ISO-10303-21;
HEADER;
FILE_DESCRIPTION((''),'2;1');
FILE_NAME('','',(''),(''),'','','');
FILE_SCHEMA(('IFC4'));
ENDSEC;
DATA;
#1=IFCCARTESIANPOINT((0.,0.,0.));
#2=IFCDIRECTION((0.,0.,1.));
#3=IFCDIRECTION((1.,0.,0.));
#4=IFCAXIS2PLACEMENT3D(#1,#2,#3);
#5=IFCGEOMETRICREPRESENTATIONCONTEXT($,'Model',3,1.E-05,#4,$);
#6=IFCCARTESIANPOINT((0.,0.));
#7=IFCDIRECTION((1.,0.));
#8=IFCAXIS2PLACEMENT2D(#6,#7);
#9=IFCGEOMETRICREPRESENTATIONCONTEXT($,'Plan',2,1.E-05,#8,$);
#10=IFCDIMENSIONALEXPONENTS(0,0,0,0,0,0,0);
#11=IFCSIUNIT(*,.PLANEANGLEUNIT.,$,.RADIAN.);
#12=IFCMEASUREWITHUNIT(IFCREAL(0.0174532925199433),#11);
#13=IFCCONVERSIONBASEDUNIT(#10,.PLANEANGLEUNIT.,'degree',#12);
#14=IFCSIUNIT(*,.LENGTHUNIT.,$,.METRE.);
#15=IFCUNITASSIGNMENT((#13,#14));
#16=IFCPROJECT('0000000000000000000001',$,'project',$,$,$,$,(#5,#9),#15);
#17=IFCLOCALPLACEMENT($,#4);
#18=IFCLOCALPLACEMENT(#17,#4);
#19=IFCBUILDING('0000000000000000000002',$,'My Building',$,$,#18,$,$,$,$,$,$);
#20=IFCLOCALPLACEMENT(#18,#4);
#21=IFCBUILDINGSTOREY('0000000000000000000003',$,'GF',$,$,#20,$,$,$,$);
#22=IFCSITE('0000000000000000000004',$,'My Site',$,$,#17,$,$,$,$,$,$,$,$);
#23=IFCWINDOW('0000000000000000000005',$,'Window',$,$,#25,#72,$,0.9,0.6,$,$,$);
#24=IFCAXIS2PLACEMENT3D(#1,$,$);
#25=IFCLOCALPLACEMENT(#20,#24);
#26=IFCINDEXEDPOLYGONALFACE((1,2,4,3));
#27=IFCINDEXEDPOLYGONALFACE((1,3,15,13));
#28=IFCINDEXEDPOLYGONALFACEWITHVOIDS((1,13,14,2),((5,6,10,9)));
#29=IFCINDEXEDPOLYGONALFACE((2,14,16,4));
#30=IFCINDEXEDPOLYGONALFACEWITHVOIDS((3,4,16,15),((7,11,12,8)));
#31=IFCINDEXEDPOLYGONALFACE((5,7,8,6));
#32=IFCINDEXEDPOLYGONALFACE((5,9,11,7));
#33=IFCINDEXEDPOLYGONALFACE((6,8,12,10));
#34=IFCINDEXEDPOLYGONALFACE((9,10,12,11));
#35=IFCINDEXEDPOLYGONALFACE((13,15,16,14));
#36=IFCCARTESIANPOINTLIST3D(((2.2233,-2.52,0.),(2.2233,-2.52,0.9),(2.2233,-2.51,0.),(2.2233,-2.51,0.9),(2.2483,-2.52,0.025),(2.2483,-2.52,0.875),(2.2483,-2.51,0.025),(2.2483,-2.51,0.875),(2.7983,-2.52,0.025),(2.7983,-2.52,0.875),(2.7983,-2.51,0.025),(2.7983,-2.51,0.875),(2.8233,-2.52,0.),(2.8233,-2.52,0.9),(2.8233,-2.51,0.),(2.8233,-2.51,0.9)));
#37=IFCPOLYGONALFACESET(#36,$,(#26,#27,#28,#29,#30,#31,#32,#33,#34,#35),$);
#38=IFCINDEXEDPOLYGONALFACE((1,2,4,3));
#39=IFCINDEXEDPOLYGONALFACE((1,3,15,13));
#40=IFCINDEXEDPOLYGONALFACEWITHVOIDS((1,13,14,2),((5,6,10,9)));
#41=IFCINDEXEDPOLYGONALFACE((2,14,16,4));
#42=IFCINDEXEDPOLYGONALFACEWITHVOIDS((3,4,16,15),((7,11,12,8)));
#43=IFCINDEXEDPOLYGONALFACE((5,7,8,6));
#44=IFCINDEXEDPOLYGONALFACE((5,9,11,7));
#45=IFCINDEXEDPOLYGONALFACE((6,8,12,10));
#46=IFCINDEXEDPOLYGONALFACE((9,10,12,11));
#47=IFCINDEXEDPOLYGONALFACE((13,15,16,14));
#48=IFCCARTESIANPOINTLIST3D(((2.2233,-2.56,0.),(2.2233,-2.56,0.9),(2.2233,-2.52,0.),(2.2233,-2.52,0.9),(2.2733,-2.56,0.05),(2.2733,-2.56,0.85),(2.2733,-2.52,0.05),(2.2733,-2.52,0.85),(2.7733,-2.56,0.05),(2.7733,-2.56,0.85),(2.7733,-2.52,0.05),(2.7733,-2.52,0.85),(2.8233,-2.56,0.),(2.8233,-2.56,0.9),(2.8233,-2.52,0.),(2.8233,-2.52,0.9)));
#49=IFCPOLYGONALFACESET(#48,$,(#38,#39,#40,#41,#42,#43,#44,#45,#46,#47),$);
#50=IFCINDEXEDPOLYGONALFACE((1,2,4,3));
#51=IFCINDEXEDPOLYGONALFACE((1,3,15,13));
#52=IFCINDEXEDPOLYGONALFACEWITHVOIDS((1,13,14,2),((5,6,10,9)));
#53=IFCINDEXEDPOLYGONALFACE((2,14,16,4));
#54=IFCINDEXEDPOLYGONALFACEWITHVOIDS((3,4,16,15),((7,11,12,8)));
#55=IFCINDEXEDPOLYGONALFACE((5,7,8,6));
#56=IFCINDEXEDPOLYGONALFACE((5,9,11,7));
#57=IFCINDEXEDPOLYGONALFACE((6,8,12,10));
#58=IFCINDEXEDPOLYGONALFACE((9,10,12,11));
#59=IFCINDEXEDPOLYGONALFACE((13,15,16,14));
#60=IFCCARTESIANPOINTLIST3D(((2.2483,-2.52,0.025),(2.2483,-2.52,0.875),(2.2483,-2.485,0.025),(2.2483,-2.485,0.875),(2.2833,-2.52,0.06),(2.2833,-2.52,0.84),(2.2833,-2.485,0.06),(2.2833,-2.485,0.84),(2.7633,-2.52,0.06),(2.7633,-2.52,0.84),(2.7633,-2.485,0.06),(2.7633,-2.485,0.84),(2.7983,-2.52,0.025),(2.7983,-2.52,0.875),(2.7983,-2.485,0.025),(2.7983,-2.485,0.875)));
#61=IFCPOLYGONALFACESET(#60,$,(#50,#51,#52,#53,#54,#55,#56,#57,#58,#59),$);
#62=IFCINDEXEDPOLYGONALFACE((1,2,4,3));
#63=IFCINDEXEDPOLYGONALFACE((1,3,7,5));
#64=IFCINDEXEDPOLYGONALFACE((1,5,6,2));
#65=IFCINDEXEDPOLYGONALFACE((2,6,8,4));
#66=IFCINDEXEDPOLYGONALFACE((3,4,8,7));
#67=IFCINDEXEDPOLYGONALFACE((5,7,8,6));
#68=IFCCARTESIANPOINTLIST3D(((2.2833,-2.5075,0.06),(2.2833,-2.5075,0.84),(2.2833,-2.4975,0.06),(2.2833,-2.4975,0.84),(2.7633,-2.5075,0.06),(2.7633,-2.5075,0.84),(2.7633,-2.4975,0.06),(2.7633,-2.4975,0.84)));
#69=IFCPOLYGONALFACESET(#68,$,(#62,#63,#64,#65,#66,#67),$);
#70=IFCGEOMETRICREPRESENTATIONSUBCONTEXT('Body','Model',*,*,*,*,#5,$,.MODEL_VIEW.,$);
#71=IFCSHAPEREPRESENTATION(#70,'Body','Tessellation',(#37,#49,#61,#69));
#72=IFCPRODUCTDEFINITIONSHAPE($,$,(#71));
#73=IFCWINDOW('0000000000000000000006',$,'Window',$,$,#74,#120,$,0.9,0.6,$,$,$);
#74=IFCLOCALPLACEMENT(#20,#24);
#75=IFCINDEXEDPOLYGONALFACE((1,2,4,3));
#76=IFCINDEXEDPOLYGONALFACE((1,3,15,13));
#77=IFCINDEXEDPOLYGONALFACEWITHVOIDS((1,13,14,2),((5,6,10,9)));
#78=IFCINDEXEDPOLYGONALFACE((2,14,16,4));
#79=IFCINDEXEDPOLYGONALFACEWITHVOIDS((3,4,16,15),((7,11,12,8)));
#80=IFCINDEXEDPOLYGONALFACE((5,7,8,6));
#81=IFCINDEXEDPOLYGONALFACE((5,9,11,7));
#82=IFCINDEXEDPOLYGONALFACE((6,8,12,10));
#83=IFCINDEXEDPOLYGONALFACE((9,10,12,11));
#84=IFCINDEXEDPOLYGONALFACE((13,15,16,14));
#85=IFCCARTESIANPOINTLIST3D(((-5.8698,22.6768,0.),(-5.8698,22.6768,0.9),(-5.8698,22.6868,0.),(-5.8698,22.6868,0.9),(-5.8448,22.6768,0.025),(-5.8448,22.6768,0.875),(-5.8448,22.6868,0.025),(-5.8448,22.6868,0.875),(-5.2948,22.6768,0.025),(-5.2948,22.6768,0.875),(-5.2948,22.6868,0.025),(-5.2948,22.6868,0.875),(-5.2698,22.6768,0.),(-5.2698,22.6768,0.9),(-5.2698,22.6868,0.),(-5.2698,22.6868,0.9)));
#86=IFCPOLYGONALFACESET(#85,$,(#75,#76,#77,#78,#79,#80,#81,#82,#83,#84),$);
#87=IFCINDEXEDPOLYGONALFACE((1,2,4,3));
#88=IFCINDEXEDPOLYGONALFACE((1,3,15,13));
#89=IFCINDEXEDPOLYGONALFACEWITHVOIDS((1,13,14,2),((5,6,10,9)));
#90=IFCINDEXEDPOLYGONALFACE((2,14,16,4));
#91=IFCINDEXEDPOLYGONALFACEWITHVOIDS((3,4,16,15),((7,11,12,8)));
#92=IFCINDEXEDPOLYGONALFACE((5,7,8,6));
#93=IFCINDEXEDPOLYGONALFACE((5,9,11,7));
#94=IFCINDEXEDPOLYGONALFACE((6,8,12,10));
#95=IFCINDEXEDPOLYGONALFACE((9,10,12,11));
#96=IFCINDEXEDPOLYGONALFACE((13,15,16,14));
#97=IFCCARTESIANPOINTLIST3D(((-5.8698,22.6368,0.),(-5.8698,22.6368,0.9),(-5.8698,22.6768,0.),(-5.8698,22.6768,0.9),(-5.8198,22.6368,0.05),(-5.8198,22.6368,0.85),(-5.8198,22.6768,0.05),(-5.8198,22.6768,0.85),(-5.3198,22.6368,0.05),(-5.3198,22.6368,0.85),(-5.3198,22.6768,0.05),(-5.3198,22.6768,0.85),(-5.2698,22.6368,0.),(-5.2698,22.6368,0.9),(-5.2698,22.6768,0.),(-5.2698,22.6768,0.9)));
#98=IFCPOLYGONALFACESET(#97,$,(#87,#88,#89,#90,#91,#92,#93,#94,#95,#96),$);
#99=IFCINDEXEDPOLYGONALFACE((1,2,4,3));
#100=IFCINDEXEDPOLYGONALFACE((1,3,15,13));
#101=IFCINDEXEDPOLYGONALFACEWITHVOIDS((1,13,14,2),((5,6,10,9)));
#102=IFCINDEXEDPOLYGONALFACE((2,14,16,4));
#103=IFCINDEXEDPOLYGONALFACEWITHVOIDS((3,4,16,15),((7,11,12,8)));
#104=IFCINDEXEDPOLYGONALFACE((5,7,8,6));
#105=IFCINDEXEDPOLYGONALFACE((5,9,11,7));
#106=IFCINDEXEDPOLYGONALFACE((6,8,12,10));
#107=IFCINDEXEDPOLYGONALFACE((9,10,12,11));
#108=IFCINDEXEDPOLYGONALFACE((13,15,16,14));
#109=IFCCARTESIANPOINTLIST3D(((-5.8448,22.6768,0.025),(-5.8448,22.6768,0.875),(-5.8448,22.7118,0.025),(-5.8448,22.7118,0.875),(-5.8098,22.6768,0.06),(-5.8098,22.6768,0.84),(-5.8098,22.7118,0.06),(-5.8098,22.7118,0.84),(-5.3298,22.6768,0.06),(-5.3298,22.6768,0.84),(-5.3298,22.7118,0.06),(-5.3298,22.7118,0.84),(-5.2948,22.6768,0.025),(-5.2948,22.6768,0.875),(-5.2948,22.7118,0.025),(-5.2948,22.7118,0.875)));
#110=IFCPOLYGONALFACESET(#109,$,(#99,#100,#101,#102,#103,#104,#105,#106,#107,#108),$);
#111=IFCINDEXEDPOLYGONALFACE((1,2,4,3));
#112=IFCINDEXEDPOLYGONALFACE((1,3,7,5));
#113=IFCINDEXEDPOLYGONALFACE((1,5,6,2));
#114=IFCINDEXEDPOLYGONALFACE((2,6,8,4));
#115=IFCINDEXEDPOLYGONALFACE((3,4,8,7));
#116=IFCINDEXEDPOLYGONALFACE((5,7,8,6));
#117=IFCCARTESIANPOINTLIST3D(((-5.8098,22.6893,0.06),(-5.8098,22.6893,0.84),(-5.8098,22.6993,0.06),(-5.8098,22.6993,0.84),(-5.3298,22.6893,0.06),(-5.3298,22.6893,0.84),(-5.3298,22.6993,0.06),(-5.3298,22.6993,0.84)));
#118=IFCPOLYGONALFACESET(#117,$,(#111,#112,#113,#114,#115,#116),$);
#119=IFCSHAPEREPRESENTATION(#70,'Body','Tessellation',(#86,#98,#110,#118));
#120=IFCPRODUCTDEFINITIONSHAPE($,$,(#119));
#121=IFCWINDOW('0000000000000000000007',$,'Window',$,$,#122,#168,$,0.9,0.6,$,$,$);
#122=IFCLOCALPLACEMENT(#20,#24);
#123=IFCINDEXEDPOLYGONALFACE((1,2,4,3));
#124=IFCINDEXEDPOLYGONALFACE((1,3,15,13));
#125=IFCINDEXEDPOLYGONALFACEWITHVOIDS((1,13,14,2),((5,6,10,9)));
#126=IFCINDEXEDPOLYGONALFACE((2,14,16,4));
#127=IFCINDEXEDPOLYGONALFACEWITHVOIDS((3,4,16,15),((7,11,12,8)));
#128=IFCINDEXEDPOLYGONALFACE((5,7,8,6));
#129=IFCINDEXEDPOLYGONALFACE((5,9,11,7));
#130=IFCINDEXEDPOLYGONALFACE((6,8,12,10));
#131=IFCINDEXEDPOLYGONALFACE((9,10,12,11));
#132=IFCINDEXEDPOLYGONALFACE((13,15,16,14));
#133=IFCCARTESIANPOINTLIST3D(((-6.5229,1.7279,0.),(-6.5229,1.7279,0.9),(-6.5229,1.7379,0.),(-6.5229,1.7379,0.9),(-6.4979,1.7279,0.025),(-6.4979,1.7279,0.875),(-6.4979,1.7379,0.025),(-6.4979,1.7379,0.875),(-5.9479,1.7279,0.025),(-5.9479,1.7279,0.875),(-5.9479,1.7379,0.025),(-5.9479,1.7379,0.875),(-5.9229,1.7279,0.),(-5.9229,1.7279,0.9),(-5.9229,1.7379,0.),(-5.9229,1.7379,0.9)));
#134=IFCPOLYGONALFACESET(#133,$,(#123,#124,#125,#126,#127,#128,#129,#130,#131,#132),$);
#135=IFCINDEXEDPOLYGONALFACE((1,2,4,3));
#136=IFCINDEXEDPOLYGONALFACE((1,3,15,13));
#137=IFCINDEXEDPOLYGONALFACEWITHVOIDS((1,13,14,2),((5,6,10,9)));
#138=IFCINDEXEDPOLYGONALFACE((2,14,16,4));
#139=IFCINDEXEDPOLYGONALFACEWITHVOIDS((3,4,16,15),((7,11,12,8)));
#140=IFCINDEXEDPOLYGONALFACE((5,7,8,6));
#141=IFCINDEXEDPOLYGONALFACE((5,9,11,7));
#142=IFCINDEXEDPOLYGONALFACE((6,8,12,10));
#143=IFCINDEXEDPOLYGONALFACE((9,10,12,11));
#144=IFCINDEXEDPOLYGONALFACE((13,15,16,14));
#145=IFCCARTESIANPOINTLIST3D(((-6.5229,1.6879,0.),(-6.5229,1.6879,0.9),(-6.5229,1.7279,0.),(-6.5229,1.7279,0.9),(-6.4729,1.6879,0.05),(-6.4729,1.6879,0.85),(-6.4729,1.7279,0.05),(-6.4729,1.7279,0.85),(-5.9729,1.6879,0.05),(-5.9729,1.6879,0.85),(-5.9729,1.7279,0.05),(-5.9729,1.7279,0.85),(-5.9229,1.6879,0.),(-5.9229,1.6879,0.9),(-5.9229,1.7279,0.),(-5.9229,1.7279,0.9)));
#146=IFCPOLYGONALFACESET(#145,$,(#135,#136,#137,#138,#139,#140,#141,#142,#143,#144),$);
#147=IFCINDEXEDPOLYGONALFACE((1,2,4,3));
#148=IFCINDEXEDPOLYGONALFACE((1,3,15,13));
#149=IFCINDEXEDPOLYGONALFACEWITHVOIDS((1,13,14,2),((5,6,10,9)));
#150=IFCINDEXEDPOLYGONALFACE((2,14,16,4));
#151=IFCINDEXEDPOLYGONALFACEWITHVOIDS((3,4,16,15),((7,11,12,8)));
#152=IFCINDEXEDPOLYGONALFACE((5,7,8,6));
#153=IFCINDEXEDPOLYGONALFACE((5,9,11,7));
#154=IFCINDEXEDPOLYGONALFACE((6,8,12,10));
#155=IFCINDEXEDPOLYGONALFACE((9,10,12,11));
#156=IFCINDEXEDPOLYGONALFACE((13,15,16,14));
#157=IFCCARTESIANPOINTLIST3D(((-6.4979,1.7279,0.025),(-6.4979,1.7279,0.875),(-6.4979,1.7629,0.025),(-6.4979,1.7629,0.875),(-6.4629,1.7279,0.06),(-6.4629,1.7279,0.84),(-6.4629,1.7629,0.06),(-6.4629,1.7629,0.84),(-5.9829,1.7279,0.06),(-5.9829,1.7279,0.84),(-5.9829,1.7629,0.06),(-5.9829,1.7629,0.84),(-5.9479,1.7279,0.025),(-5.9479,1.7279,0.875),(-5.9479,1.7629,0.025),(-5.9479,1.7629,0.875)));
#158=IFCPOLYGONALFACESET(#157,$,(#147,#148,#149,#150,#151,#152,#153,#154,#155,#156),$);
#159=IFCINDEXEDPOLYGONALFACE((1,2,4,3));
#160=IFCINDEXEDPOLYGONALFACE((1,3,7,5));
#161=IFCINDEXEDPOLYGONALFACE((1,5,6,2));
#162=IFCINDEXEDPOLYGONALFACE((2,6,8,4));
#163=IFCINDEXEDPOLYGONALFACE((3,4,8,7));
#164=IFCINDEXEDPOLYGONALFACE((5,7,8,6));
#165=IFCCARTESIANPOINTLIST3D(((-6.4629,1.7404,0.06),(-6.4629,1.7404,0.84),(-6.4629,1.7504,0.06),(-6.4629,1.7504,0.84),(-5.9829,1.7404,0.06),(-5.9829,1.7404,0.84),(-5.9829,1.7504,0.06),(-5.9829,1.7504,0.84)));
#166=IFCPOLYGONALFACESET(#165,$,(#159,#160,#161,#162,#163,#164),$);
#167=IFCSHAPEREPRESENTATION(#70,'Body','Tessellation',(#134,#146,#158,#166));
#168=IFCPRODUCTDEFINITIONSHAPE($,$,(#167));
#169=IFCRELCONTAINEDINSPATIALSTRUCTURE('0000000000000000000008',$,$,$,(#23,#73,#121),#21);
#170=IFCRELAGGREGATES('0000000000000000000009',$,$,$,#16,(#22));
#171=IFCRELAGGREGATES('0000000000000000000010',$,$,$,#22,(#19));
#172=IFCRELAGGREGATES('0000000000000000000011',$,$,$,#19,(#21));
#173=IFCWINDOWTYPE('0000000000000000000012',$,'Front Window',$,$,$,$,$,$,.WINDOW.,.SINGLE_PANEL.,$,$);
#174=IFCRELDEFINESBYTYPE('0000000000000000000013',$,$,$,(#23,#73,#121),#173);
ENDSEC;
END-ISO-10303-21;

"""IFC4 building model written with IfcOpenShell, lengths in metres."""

from ifc_helpers import new_model, entity, si_unit, converted_unit, frame, origin_with_axes, origin_2d_with_axis, place, context, subcontext, project, spatial, line, indexed_curve, outline, extrude, shape, source, transform, mapped, type_object, type_shapes, element, save


model = new_model("IFC4")

# Units and contexts
model_context = context("Model", 3, precision=1e-05, world=origin_with_axes())
plan_context = context("Plan", 2, precision=1e-05, world=origin_2d_with_axis())
body_context_1 = subcontext(model_context, "Body", "Model", "MODEL_VIEW")
body_context_2 = subcontext(plan_context, "Body", "Plan", "PLAN_VIEW")
ifc_project = project(units=[converted_unit("PLANEANGLEUNIT", "degree", entity("IfcReal", 0.0174532925199433), si_unit("PLANEANGLEUNIT", "RADIAN"), dimensions=[0, 0, 0, 0, 0, 0, 0]), si_unit("LENGTHUNIT", "METRE")], contexts=[model_context, plan_context])

# Site, building, storey
site_placement = place(None, origin_with_axes())
site = spatial("IfcSite", under=ifc_project, at=site_placement, Name="My Site")
building_placement = place(site_placement, origin_with_axes())
building = spatial("IfcBuilding", under=site, at=building_placement, Name="My Building")
storey_placement = place(building_placement, origin_with_axes())
storey = spatial("IfcBuildingStorey", under=building, at=storey_placement, Name="GF")

# Shared definitions
window_type_1 = type_object("IfcWindowType", Name="Front Window", PartitioningType="SINGLE_PANEL", PredefinedType="WINDOW")
shared_shape_1 = source(origin_with_axes(), body_context_1, "Body", "SweptSolid", [
    extrude(outline(indexed_curve([(0.0, 0.0), (0.6, 0.0), (0.6, 0.9), (0.0, 0.9)], segments=[line(1, 2, 3, 4, 1)]), holes=[indexed_curve([(0.025, 0.025), (0.575, 0.025), (0.575, 0.875), (0.025, 0.875)], segments=[line(1, 2, 3, 4, 1)])]), frame((0.0, 0.09, 0.0), z_axis=(0.0, -1.0, 0.0), x_axis=(1.0, 0.0, 0.0)), (0.0, 0.0, -1.0), 0.01),
    extrude(outline(indexed_curve([(0.0, 0.0), (0.6, 0.0), (0.6, 0.9), (0.0, 0.9)], segments=[line(1, 2, 3, 4, 1)]), holes=[indexed_curve([(0.05, 0.05), (0.55, 0.05), (0.55, 0.85), (0.05, 0.85)], segments=[line(1, 2, 3, 4, 1)])]), frame((0.0, 0.05, 0.0), z_axis=(0.0, -1.0, 0.0), x_axis=(1.0, 0.0, 0.0)), (0.0, 0.0, -1.0), 0.04),
    extrude(outline(indexed_curve([(0.0, 0.0), (0.55, 0.0), (0.55, 0.85), (0.0, 0.85)], segments=[line(1, 2, 3, 4, 1)]), holes=[indexed_curve([(0.035, 0.035), (0.515, 0.035), (0.515, 0.815), (0.035, 0.815)], segments=[line(1, 2, 3, 4, 1)])]), frame((0.025, 0.09, 0.025), z_axis=(0.0, -1.0, 0.0), x_axis=(1.0, 0.0, 0.0)), (0.0, 0.0, -1.0), 0.035),
    extrude(outline(indexed_curve([(0.035, 0.035), (0.515, 0.035), (0.515, 0.815), (0.035, 0.815)], segments=[line(1, 2, 3, 4, 1)])), frame((0.025, 0.1025, 0.025), z_axis=(0.0, -1.0, 0.0), x_axis=(1.0, 0.0, 0.0)), (0.0, 0.0, -1.0), 0.01),
])
shared_shape_2 = source(origin_with_axes(), body_context_2, "Body", "Curve2D", [
    entity("IfcIndexedPolyCurve", entity("IfcCartesianPointList2D", [[0.05, 0.05], [0.55, 0.05]])),
    entity("IfcIndexedPolyCurve", entity("IfcCartesianPointList2D", [[0.0, 0.1], [0.025, 0.1], [0.025, 0.09], [0.05, 0.09], [0.05, 0.05], [0.0, 0.05]]), [entity("IfcLineIndex", [1, 2, 3, 4, 5, 6, 1])]),
    entity("IfcIndexedPolyCurve", entity("IfcCartesianPointList2D", [[0.6, 0.1], [0.575, 0.1], [0.575, 0.09], [0.55, 0.09], [0.55, 0.05], [0.6, 0.05]]), [entity("IfcLineIndex", [1, 2, 3, 4, 5, 6, 1])]),
    entity("IfcIndexedPolyCurve", entity("IfcCartesianPointList2D", [[0.025, 0.09], [0.06, 0.09], [0.06, 0.125], [0.025, 0.125]]), [entity("IfcLineIndex", [1, 2, 3, 4, 1])]),
    entity("IfcIndexedPolyCurve", entity("IfcCartesianPointList2D", [[0.575, 0.09], [0.54, 0.09], [0.54, 0.125], [0.575, 0.125]]), [entity("IfcLineIndex", [1, 2, 3, 4, 1])]),
    entity("IfcIndexedPolyCurve", entity("IfcCartesianPointList2D", [[0.06, 0.09], [0.54, 0.09]])),
    entity("IfcIndexedPolyCurve", entity("IfcCartesianPointList2D", [[0.06, 0.125], [0.54, 0.125]])),
    entity("IfcIndexedPolyCurve", entity("IfcCartesianPointList2D", [[0.06, 0.1075], [0.54, 0.1075]])),
])
type_shapes(window_type_1, [shared_shape_1, shared_shape_2])

# Windows
for number, where, z_axis, x_axis, name in (
    (1, (2.2233, -2.61, 0.0), (0.0, 0.0, 1.0), (1.0, 0.0, 0.0), "Window"),
    (2, (-5.8698, 22.5868, 0.0), (0.0, 0.0, 1.0), (1.0, 0.0, 0.0), "Window"),
    (3, (-6.5229, 1.6379, 0.0), (0.0, 0.0, 1.0), (1.0, 0.0, 0.0), "Window"),
):
    element("IfcWindow", number, at=place(storey_placement, frame(where, z_axis=z_axis, x_axis=x_axis)), inside=storey, type_object=window_type_1, Name=name, OverallHeight=0.9, OverallWidth=0.6, shapes=[
        shape(body_context_1, "Body", "MappedRepresentation", [mapped(shared_shape_1, transform((0.0, 0.0, 0.0), x_axis=(1.0, 0.0, 0.0), y_axis=(0.0, 1.0, 0.0), z_axis=(0.0, 0.0, 1.0), scale=1.0))]),
        shape(body_context_2, "Body", "MappedRepresentation", [mapped(shared_shape_2, transform((0.0, 0.0, 0.0), x_axis=(1.0, 0.0, 0.0), y_axis=(0.0, 1.0, 0.0), z_axis=(0.0, 0.0, 1.0), scale=1.0))]),
    ])

save(model, "model.ifc")
